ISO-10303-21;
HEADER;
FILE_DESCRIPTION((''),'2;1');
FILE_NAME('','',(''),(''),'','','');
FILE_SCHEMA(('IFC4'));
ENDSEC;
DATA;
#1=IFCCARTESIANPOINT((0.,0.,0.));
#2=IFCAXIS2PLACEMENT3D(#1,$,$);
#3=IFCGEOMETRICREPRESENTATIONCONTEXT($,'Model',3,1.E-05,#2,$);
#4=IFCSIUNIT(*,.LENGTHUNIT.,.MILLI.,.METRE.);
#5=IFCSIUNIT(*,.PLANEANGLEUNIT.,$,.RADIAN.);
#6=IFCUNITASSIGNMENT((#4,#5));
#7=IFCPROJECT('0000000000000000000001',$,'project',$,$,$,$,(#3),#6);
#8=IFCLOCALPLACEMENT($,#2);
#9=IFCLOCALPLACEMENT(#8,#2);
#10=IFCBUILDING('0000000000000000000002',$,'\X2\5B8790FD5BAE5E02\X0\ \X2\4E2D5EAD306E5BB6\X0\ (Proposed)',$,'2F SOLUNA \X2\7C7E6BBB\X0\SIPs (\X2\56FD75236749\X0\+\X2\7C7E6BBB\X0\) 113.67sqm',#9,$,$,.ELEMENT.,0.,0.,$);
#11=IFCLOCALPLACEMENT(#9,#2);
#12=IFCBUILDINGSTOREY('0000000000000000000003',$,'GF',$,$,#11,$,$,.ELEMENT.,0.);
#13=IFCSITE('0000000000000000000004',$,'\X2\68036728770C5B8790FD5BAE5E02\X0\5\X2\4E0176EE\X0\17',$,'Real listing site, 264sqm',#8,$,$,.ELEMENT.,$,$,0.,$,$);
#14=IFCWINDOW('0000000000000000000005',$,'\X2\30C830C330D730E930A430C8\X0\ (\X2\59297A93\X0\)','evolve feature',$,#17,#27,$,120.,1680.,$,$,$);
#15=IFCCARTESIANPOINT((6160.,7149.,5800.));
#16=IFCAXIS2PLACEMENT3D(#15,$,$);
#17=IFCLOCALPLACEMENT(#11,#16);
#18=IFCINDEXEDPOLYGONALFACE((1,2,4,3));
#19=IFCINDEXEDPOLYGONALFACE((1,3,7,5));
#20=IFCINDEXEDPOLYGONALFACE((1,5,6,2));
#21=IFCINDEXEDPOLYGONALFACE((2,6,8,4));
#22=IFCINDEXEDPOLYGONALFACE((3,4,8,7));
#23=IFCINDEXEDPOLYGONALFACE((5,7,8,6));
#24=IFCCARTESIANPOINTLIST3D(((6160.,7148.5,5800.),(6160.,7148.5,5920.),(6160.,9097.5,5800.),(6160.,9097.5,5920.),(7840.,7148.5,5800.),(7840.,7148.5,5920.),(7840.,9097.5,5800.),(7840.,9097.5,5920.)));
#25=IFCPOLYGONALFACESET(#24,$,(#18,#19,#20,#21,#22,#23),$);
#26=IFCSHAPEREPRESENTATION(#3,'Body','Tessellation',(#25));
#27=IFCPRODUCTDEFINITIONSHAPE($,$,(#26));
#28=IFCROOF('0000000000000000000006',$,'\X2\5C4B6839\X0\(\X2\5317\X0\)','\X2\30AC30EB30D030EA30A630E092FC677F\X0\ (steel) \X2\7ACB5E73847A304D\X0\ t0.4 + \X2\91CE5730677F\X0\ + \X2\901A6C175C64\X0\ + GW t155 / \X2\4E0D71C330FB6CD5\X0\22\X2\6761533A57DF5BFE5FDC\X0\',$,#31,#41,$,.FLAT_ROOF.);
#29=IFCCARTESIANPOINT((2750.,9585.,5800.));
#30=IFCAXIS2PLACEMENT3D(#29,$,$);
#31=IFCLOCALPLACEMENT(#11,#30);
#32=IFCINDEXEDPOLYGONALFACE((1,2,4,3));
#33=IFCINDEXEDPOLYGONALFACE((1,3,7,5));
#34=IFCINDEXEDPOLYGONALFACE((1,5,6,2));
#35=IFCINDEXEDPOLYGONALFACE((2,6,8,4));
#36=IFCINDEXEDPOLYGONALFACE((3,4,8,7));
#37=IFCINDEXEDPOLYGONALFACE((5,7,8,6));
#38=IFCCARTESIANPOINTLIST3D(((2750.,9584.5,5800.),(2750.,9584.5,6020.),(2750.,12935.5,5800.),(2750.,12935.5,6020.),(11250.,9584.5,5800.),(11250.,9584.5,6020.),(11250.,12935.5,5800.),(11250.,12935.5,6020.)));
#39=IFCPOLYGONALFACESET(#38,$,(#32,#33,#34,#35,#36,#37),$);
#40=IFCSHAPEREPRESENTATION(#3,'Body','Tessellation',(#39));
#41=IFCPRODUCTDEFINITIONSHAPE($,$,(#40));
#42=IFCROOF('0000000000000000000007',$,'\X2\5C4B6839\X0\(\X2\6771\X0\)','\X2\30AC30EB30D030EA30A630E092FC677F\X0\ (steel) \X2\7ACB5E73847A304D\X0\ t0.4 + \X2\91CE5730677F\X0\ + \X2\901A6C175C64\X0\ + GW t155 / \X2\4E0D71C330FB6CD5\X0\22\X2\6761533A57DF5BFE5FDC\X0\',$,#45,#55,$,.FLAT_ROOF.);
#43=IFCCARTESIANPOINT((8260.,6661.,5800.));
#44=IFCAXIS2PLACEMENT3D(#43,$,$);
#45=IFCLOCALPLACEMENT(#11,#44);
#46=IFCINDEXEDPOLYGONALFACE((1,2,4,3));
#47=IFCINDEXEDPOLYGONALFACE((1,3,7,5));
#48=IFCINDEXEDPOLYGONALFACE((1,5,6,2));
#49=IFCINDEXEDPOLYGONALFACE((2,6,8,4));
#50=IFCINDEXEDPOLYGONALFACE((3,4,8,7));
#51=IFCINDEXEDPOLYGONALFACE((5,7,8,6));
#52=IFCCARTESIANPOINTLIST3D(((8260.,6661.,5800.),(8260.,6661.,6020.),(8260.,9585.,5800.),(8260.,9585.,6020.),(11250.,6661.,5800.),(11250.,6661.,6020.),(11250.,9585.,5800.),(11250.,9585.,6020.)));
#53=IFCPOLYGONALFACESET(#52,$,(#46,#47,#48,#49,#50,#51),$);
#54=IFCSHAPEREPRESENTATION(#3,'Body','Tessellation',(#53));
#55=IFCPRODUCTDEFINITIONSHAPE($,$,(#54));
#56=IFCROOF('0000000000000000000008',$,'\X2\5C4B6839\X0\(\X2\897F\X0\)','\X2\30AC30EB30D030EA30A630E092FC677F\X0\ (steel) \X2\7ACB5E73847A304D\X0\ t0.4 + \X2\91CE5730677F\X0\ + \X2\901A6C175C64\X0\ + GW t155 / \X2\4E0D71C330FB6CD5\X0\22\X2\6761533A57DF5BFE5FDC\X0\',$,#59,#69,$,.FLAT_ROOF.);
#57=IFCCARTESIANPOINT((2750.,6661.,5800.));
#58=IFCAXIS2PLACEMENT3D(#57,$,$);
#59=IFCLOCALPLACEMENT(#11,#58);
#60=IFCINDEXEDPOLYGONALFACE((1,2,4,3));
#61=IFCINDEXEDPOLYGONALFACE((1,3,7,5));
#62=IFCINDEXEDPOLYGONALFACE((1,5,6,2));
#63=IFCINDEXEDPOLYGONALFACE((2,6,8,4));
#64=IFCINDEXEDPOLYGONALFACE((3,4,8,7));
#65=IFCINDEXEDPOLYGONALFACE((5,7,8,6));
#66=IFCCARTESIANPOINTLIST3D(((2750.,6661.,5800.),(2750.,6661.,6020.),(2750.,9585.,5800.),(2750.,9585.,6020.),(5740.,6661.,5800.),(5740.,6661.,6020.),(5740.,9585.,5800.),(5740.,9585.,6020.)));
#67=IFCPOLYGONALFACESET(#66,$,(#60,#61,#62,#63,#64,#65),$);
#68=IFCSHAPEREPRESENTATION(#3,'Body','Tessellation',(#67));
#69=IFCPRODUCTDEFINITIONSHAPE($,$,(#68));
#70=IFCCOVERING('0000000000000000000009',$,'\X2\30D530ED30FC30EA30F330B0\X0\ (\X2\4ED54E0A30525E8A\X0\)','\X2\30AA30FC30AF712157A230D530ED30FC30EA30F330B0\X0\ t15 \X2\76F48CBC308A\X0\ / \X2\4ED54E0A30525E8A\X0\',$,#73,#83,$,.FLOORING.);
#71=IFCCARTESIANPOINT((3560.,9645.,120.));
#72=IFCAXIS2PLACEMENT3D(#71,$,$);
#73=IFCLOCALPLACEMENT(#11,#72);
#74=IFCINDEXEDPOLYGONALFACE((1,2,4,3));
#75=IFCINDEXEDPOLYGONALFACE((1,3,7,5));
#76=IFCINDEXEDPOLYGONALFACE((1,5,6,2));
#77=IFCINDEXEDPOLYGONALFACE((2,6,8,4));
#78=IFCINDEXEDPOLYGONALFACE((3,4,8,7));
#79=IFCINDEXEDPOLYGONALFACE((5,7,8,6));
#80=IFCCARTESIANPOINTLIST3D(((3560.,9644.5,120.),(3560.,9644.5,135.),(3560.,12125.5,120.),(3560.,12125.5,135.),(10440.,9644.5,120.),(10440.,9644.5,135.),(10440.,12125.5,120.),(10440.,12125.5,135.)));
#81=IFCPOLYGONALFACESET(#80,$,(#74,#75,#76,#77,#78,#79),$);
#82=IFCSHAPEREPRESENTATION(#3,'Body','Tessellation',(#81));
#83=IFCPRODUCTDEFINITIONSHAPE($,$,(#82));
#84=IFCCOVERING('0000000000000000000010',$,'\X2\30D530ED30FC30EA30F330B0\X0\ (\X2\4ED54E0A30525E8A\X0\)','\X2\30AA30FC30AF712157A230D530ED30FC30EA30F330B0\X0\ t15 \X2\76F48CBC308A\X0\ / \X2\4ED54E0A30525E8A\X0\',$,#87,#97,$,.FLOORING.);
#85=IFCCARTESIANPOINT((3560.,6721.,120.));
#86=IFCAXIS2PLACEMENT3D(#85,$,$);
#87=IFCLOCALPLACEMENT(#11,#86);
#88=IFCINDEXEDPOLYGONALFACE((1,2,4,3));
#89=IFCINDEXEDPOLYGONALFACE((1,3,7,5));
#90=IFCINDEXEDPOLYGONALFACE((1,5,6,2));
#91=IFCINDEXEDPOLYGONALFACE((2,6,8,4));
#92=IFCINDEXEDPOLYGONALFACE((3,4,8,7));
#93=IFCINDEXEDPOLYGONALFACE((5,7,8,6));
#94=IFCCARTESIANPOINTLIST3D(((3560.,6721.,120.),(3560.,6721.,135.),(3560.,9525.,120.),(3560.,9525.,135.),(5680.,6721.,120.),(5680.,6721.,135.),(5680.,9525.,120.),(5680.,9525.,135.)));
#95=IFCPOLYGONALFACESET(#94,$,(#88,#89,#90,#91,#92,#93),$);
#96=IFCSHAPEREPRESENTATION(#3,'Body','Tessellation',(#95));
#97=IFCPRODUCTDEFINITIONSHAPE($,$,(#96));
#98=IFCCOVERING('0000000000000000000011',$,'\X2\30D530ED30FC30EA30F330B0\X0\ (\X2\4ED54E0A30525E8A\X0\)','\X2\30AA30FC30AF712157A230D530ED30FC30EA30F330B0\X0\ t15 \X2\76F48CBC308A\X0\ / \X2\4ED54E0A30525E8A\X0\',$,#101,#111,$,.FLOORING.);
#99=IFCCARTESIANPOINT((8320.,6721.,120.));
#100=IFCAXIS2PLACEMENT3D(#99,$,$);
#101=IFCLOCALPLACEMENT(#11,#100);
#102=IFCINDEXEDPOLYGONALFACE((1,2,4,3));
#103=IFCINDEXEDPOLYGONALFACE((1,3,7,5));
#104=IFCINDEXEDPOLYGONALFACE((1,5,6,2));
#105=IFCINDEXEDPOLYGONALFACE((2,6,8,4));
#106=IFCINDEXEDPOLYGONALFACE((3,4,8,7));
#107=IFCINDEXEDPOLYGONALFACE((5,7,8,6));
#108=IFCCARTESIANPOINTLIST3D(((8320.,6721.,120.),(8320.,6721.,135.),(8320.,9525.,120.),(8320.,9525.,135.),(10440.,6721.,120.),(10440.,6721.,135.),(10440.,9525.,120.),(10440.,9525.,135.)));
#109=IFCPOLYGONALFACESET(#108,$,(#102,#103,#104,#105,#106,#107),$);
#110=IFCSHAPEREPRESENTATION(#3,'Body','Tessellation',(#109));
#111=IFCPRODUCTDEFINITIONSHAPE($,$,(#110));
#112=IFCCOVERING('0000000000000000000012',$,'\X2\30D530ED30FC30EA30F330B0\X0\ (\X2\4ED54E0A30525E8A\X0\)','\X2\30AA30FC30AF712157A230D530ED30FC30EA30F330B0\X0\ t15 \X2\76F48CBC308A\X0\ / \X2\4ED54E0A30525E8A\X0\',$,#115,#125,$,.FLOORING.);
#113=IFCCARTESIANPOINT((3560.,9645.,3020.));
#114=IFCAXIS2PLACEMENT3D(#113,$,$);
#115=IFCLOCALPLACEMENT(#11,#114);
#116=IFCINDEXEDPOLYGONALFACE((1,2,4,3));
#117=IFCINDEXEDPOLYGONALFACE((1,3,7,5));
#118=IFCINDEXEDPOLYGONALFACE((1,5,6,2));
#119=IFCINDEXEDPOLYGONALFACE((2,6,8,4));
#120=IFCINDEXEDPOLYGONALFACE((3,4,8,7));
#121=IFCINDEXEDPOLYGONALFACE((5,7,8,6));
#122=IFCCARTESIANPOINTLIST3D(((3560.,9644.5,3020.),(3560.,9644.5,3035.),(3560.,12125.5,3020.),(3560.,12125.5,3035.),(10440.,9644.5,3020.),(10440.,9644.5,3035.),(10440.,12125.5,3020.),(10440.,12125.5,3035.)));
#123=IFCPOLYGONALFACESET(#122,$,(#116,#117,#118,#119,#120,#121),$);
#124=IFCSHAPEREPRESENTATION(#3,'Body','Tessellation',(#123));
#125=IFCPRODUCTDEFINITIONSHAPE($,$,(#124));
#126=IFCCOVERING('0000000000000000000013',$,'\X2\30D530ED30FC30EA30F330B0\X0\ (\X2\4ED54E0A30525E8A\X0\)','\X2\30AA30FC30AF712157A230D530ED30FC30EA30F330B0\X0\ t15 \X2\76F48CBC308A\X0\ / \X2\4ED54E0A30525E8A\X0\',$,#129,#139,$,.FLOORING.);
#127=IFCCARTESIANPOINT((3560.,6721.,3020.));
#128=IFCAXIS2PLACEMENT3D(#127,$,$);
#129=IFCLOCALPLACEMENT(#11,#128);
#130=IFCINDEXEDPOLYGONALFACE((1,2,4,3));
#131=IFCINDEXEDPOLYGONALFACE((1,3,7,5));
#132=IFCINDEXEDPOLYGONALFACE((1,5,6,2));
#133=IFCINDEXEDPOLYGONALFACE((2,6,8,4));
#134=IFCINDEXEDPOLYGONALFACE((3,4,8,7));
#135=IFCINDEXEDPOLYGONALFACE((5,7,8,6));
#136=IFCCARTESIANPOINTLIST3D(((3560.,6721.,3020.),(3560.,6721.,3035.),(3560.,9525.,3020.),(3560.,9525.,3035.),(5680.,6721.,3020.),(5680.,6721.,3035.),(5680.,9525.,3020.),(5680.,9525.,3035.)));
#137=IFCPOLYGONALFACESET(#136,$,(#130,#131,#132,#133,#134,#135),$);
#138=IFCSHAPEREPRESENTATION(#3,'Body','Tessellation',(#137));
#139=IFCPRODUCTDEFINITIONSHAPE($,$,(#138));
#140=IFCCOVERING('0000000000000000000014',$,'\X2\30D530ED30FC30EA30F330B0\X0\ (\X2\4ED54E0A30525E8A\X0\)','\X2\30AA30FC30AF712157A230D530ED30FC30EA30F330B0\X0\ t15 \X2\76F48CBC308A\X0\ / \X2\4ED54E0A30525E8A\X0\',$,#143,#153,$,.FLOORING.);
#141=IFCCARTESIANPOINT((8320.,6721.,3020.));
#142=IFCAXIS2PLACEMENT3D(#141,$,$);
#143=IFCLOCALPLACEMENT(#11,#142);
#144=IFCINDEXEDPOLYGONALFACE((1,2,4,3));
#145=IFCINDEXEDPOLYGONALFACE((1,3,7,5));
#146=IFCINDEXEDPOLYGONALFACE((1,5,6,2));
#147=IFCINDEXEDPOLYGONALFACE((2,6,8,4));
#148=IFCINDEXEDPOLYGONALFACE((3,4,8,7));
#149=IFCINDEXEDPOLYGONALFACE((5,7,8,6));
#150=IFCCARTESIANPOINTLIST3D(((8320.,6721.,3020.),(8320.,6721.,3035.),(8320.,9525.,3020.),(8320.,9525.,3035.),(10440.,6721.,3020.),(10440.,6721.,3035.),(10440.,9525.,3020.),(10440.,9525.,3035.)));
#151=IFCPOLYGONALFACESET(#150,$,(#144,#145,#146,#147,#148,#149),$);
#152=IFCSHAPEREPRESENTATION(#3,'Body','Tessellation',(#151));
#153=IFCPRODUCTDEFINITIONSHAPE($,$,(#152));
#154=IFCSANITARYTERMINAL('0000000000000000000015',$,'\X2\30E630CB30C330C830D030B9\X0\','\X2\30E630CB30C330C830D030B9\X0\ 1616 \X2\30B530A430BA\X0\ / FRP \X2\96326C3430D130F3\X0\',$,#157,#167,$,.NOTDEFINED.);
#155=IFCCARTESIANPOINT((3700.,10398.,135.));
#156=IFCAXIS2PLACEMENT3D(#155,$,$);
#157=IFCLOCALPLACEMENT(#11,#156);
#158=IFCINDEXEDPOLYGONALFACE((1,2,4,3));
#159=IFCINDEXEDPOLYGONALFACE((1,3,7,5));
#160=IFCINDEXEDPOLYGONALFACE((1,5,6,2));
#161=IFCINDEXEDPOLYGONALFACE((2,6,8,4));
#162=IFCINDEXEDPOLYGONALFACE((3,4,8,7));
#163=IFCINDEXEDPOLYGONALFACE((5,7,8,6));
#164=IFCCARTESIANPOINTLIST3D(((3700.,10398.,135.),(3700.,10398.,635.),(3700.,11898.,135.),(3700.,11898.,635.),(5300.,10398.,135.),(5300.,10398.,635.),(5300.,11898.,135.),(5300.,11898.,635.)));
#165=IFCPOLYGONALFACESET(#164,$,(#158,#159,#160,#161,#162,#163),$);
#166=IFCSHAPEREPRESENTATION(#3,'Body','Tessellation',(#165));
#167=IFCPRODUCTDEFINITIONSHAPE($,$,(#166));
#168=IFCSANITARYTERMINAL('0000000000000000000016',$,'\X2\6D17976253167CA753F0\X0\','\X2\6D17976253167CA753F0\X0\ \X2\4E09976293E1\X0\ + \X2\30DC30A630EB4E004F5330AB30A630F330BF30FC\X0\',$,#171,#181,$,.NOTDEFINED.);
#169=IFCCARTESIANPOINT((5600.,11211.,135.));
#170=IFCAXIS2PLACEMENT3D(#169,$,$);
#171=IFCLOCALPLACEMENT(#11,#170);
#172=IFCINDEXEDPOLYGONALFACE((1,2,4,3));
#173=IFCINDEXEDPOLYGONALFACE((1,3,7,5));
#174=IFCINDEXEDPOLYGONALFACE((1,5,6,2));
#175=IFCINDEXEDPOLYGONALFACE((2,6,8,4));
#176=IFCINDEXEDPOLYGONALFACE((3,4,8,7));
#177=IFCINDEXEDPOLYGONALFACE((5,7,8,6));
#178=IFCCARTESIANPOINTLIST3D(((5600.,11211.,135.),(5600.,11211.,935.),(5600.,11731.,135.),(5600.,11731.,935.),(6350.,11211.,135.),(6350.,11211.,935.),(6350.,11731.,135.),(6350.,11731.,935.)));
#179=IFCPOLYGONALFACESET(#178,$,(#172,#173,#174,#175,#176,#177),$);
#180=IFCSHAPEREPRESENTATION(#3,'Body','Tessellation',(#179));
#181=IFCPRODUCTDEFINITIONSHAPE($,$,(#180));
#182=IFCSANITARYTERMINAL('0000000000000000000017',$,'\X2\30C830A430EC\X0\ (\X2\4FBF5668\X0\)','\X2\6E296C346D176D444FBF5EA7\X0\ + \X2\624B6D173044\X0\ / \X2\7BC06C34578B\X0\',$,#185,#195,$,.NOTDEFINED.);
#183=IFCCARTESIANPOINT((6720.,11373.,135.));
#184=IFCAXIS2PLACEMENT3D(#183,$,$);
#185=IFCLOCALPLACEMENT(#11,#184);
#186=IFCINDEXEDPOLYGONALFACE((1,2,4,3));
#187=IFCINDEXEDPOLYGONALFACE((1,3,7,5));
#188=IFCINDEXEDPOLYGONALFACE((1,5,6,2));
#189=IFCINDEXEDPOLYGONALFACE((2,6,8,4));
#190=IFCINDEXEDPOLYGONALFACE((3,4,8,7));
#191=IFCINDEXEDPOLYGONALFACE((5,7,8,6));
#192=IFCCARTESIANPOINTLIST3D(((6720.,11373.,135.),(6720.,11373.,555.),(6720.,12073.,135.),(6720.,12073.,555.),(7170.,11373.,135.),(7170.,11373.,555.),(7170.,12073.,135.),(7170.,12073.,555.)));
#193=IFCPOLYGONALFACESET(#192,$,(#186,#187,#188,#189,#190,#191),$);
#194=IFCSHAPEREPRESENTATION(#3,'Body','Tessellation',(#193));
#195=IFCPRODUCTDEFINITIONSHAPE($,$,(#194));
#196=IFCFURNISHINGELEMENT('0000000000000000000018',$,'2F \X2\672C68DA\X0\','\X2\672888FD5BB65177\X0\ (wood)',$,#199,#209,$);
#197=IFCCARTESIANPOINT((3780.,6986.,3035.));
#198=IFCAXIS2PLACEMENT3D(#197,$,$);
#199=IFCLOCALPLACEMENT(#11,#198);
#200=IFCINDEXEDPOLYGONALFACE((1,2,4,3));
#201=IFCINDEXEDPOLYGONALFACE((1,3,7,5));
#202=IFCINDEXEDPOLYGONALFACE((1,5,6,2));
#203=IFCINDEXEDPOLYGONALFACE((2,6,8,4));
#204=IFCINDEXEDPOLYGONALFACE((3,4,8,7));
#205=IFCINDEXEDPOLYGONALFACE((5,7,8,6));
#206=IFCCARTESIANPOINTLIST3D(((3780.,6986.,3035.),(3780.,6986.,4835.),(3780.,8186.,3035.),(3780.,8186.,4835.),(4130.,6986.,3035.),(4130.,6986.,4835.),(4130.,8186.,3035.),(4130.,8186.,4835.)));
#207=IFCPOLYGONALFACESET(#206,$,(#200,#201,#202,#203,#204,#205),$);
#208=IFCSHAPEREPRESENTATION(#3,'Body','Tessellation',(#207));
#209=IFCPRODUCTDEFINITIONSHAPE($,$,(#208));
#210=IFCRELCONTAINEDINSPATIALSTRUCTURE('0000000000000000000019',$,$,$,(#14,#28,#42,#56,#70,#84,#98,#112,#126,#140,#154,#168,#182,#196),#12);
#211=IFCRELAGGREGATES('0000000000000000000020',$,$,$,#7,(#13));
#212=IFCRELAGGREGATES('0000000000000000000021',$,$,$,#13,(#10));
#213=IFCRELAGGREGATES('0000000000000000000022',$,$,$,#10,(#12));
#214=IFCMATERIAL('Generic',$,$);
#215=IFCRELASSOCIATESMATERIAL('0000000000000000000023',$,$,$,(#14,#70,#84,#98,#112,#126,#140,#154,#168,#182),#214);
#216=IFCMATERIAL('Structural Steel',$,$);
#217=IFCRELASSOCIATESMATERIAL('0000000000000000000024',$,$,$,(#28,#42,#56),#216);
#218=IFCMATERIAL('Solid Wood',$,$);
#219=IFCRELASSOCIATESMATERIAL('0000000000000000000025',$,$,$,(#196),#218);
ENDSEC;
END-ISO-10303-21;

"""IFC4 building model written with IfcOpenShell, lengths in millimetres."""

from ifc_helpers import new_model, si_unit, frame, frame_2d, origin, place, context, project, spatial, rectangle, extrude, material, element, save


model = new_model("IFC4")

# Units and contexts
model_context = context("Model", 3, precision=1e-05, world=origin())
ifc_project = project(units=[si_unit("LENGTHUNIT", "METRE", prefix="MILLI"), si_unit("PLANEANGLEUNIT", "RADIAN")], contexts=[model_context])

# Site, building, storey
site_placement = place(None, origin())
site = spatial("IfcSite", under=ifc_project, at=site_placement, Name="栃木県宇都宮市5丁目17", ObjectType="Real listing site, 264sqm", CompositionType="ELEMENT", RefElevation=0.0)
building_placement = place(site_placement, origin())
building = spatial("IfcBuilding", under=site, at=building_placement, Name="宇都宮市 中庭の家 (Proposed)", ObjectType="2F SOLUNA 籾殻SIPs (国産杉+籾殻) 113.67sqm", CompositionType="ELEMENT", ElevationOfRefHeight=0.0, ElevationOfTerrain=0.0)
storey_placement = place(building_placement, origin())
storey = spatial("IfcBuildingStorey", under=building, at=storey_placement, Name="GF", CompositionType="ELEMENT", Elevation=0.0)

# Shared definitions
ifc_material_1 = material(Name="Solid Wood")

# Window
ifc_material_2 = material(Name="Generic")
window_1_placement = place(storey_placement, frame((6160.0, 7149.0, 5800.0)))
element("IfcWindow", 1, at=window_1_placement, inside=storey, material=ifc_material_2, Name="トップライト (天窓)", Description="evolve feature", OverallHeight=120.0, OverallWidth=1680.0, context=model_context, shape_type="SweptSolid", body=[
    extrude(rectangle(XDim=1680.0, YDim=1949.0, at=frame_2d((840.0, 974.0))), frame((6160.0, 7149.0, 5800.0)), (0.0, 0.0, 1.0), 120.0),
])

# Roofs
ifc_material_3 = material(Name="Structural Steel")
roof_1_placement = place(storey_placement, frame((2750.0, 9585.0, 5800.0)))
element("IfcRoof", 2, at=roof_1_placement, inside=storey, material=ifc_material_3, Name="屋根(北)", Description="ガルバリウム鋼板 (steel) 立平葺き t0.4 + 野地板 + 通気層 + GW t155 / 不燃・法22条区域対応", PredefinedType="FLAT_ROOF", context=model_context, shape_type="SweptSolid", body=[
    extrude(rectangle(XDim=8500.0, YDim=3351.0, at=frame_2d((4250.0, 1675.0))), frame((2750.0, 9585.0, 5800.0)), (0.0, 0.0, 1.0), 220.0),
])
roof_2_placement = place(storey_placement, frame((8260.0, 6661.0, 5800.0)))
element("IfcRoof", 3, at=roof_2_placement, inside=storey, material=ifc_material_3, Name="屋根(東)", Description="ガルバリウム鋼板 (steel) 立平葺き t0.4 + 野地板 + 通気層 + GW t155 / 不燃・法22条区域対応", PredefinedType="FLAT_ROOF", context=model_context, shape_type="SweptSolid", body=[
    extrude(rectangle(XDim=2990.0, YDim=2924.0, at=frame_2d((1495.0, 1462.0))), frame((8260.0, 6661.0, 5800.0)), (0.0, 0.0, 1.0), 220.0),
])
roof_3_placement = place(storey_placement, frame((2750.0, 6661.0, 5800.0)))
element("IfcRoof", 4, at=roof_3_placement, inside=storey, material=ifc_material_3, Name="屋根(西)", Description="ガルバリウム鋼板 (steel) 立平葺き t0.4 + 野地板 + 通気層 + GW t155 / 不燃・法22条区域対応", PredefinedType="FLAT_ROOF", context=model_context, shape_type="SweptSolid", body=[
    extrude(rectangle(XDim=2990.0, YDim=2924.0, at=frame_2d((1495.0, 1462.0))), frame((2750.0, 6661.0, 5800.0)), (0.0, 0.0, 1.0), 220.0),
])

# Coverings
covering_1_placement = place(storey_placement, frame((3560.0, 9645.0, 120.0)))
element("IfcCovering", 5, at=covering_1_placement, inside=storey, material=ifc_material_2, Name="フローリング (仕上げ床)", Description="オーク無垢フローリング t15 直貼り / 仕上げ床", PredefinedType="FLOORING", context=model_context, shape_type="SweptSolid", body=[
    extrude(rectangle(XDim=6880.0, YDim=2481.0, at=frame_2d((3440.0, 1240.0))), frame((3560.0, 9645.0, 120.0)), (0.0, 0.0, 1.0), 15.0),
])
covering_2_placement = place(storey_placement, frame((3560.0, 6721.0, 120.0)))
element("IfcCovering", 6, at=covering_2_placement, inside=storey, material=ifc_material_2, Name="フローリング (仕上げ床)", Description="オーク無垢フローリング t15 直貼り / 仕上げ床", PredefinedType="FLOORING", context=model_context, shape_type="SweptSolid", body=[
    extrude(rectangle(XDim=2120.0, YDim=2804.0, at=frame_2d((1060.0, 1402.0))), frame((3560.0, 6721.0, 120.0)), (0.0, 0.0, 1.0), 15.0),
])
covering_3_placement = place(storey_placement, frame((8320.0, 6721.0, 120.0)))
element("IfcCovering", 7, at=covering_3_placement, inside=storey, material=ifc_material_2, Name="フローリング (仕上げ床)", Description="オーク無垢フローリング t15 直貼り / 仕上げ床", PredefinedType="FLOORING", context=model_context, shape_type="SweptSolid", body=[
    extrude(rectangle(XDim=2120.0, YDim=2804.0, at=frame_2d((1060.0, 1402.0))), frame((8320.0, 6721.0, 120.0)), (0.0, 0.0, 1.0), 15.0),
])
covering_4_placement = place(storey_placement, frame((3560.0, 9645.0, 3020.0)))
element("IfcCovering", 8, at=covering_4_placement, inside=storey, material=ifc_material_2, Name="フローリング (仕上げ床)", Description="オーク無垢フローリング t15 直貼り / 仕上げ床", PredefinedType="FLOORING", context=model_context, shape_type="SweptSolid", body=[
    extrude(rectangle(XDim=6880.0, YDim=2481.0, at=frame_2d((3440.0, 1240.0))), frame((3560.0, 9645.0, 3020.0)), (0.0, 0.0, 1.0), 15.0),
])
covering_5_placement = place(storey_placement, frame((3560.0, 6721.0, 3020.0)))
element("IfcCovering", 9, at=covering_5_placement, inside=storey, material=ifc_material_2, Name="フローリング (仕上げ床)", Description="オーク無垢フローリング t15 直貼り / 仕上げ床", PredefinedType="FLOORING", context=model_context, shape_type="SweptSolid", body=[
    extrude(rectangle(XDim=2120.0, YDim=2804.0, at=frame_2d((1060.0, 1402.0))), frame((3560.0, 6721.0, 3020.0)), (0.0, 0.0, 1.0), 15.0),
])
covering_6_placement = place(storey_placement, frame((8320.0, 6721.0, 3020.0)))
element("IfcCovering", 10, at=covering_6_placement, inside=storey, material=ifc_material_2, Name="フローリング (仕上げ床)", Description="オーク無垢フローリング t15 直貼り / 仕上げ床", PredefinedType="FLOORING", context=model_context, shape_type="SweptSolid", body=[
    extrude(rectangle(XDim=2120.0, YDim=2804.0, at=frame_2d((1060.0, 1402.0))), frame((8320.0, 6721.0, 3020.0)), (0.0, 0.0, 1.0), 15.0),
])

# Sanitary terminals
sanitary_terminal_1_placement = place(storey_placement, frame((3700.0, 10398.0, 135.0)))
element("IfcSanitaryTerminal", 11, at=sanitary_terminal_1_placement, inside=storey, material=ifc_material_2, Name="ユニットバス", Description="ユニットバス 1616 サイズ / FRP 防水パン", PredefinedType="NOTDEFINED", context=model_context, shape_type="SweptSolid", body=[
    extrude(rectangle(XDim=1600.0, YDim=1500.0, at=frame_2d((800.0, 750.0))), frame((3700.0, 10398.0, 135.0)), (0.0, 0.0, 1.0), 500.0),
])
sanitary_terminal_2_placement = place(storey_placement, frame((5600.0, 11211.0, 135.0)))
element("IfcSanitaryTerminal", 12, at=sanitary_terminal_2_placement, inside=storey, material=ifc_material_2, Name="洗面化粧台", Description="洗面化粧台 三面鏡 + ボウル一体カウンター", PredefinedType="NOTDEFINED", context=model_context, shape_type="SweptSolid", body=[
    extrude(rectangle(XDim=750.0, YDim=520.0, at=frame_2d((375.0, 260.0))), frame((5600.0, 11211.0, 135.0)), (0.0, 0.0, 1.0), 800.0),
])
sanitary_terminal_3_placement = place(storey_placement, frame((6720.0, 11373.0, 135.0)))
element("IfcSanitaryTerminal", 13, at=sanitary_terminal_3_placement, inside=storey, material=ifc_material_2, Name="トイレ (便器)", Description="温水洗浄便座 + 手洗い / 節水型", PredefinedType="NOTDEFINED", context=model_context, shape_type="SweptSolid", body=[
    extrude(rectangle(XDim=450.0, YDim=700.0, at=frame_2d((225.0, 350.0))), frame((6720.0, 11373.0, 135.0)), (0.0, 0.0, 1.0), 420.0),
])

# Furnishing element
furnishing_placement = place(storey_placement, frame((3780.0, 6986.0, 3035.0)))
element("IfcFurnishingElement", 14, at=furnishing_placement, inside=storey, material=ifc_material_1, Name="2F 本棚", Description="木製家具 (wood)", context=model_context, shape_type="SweptSolid", body=[
    extrude(rectangle(XDim=350.0, YDim=1200.0, at=frame_2d((175.0, 600.0))), frame((3780.0, 6986.0, 3035.0)), (0.0, 0.0, 1.0), 1800.0),
])

save(model, "model.ifc")
